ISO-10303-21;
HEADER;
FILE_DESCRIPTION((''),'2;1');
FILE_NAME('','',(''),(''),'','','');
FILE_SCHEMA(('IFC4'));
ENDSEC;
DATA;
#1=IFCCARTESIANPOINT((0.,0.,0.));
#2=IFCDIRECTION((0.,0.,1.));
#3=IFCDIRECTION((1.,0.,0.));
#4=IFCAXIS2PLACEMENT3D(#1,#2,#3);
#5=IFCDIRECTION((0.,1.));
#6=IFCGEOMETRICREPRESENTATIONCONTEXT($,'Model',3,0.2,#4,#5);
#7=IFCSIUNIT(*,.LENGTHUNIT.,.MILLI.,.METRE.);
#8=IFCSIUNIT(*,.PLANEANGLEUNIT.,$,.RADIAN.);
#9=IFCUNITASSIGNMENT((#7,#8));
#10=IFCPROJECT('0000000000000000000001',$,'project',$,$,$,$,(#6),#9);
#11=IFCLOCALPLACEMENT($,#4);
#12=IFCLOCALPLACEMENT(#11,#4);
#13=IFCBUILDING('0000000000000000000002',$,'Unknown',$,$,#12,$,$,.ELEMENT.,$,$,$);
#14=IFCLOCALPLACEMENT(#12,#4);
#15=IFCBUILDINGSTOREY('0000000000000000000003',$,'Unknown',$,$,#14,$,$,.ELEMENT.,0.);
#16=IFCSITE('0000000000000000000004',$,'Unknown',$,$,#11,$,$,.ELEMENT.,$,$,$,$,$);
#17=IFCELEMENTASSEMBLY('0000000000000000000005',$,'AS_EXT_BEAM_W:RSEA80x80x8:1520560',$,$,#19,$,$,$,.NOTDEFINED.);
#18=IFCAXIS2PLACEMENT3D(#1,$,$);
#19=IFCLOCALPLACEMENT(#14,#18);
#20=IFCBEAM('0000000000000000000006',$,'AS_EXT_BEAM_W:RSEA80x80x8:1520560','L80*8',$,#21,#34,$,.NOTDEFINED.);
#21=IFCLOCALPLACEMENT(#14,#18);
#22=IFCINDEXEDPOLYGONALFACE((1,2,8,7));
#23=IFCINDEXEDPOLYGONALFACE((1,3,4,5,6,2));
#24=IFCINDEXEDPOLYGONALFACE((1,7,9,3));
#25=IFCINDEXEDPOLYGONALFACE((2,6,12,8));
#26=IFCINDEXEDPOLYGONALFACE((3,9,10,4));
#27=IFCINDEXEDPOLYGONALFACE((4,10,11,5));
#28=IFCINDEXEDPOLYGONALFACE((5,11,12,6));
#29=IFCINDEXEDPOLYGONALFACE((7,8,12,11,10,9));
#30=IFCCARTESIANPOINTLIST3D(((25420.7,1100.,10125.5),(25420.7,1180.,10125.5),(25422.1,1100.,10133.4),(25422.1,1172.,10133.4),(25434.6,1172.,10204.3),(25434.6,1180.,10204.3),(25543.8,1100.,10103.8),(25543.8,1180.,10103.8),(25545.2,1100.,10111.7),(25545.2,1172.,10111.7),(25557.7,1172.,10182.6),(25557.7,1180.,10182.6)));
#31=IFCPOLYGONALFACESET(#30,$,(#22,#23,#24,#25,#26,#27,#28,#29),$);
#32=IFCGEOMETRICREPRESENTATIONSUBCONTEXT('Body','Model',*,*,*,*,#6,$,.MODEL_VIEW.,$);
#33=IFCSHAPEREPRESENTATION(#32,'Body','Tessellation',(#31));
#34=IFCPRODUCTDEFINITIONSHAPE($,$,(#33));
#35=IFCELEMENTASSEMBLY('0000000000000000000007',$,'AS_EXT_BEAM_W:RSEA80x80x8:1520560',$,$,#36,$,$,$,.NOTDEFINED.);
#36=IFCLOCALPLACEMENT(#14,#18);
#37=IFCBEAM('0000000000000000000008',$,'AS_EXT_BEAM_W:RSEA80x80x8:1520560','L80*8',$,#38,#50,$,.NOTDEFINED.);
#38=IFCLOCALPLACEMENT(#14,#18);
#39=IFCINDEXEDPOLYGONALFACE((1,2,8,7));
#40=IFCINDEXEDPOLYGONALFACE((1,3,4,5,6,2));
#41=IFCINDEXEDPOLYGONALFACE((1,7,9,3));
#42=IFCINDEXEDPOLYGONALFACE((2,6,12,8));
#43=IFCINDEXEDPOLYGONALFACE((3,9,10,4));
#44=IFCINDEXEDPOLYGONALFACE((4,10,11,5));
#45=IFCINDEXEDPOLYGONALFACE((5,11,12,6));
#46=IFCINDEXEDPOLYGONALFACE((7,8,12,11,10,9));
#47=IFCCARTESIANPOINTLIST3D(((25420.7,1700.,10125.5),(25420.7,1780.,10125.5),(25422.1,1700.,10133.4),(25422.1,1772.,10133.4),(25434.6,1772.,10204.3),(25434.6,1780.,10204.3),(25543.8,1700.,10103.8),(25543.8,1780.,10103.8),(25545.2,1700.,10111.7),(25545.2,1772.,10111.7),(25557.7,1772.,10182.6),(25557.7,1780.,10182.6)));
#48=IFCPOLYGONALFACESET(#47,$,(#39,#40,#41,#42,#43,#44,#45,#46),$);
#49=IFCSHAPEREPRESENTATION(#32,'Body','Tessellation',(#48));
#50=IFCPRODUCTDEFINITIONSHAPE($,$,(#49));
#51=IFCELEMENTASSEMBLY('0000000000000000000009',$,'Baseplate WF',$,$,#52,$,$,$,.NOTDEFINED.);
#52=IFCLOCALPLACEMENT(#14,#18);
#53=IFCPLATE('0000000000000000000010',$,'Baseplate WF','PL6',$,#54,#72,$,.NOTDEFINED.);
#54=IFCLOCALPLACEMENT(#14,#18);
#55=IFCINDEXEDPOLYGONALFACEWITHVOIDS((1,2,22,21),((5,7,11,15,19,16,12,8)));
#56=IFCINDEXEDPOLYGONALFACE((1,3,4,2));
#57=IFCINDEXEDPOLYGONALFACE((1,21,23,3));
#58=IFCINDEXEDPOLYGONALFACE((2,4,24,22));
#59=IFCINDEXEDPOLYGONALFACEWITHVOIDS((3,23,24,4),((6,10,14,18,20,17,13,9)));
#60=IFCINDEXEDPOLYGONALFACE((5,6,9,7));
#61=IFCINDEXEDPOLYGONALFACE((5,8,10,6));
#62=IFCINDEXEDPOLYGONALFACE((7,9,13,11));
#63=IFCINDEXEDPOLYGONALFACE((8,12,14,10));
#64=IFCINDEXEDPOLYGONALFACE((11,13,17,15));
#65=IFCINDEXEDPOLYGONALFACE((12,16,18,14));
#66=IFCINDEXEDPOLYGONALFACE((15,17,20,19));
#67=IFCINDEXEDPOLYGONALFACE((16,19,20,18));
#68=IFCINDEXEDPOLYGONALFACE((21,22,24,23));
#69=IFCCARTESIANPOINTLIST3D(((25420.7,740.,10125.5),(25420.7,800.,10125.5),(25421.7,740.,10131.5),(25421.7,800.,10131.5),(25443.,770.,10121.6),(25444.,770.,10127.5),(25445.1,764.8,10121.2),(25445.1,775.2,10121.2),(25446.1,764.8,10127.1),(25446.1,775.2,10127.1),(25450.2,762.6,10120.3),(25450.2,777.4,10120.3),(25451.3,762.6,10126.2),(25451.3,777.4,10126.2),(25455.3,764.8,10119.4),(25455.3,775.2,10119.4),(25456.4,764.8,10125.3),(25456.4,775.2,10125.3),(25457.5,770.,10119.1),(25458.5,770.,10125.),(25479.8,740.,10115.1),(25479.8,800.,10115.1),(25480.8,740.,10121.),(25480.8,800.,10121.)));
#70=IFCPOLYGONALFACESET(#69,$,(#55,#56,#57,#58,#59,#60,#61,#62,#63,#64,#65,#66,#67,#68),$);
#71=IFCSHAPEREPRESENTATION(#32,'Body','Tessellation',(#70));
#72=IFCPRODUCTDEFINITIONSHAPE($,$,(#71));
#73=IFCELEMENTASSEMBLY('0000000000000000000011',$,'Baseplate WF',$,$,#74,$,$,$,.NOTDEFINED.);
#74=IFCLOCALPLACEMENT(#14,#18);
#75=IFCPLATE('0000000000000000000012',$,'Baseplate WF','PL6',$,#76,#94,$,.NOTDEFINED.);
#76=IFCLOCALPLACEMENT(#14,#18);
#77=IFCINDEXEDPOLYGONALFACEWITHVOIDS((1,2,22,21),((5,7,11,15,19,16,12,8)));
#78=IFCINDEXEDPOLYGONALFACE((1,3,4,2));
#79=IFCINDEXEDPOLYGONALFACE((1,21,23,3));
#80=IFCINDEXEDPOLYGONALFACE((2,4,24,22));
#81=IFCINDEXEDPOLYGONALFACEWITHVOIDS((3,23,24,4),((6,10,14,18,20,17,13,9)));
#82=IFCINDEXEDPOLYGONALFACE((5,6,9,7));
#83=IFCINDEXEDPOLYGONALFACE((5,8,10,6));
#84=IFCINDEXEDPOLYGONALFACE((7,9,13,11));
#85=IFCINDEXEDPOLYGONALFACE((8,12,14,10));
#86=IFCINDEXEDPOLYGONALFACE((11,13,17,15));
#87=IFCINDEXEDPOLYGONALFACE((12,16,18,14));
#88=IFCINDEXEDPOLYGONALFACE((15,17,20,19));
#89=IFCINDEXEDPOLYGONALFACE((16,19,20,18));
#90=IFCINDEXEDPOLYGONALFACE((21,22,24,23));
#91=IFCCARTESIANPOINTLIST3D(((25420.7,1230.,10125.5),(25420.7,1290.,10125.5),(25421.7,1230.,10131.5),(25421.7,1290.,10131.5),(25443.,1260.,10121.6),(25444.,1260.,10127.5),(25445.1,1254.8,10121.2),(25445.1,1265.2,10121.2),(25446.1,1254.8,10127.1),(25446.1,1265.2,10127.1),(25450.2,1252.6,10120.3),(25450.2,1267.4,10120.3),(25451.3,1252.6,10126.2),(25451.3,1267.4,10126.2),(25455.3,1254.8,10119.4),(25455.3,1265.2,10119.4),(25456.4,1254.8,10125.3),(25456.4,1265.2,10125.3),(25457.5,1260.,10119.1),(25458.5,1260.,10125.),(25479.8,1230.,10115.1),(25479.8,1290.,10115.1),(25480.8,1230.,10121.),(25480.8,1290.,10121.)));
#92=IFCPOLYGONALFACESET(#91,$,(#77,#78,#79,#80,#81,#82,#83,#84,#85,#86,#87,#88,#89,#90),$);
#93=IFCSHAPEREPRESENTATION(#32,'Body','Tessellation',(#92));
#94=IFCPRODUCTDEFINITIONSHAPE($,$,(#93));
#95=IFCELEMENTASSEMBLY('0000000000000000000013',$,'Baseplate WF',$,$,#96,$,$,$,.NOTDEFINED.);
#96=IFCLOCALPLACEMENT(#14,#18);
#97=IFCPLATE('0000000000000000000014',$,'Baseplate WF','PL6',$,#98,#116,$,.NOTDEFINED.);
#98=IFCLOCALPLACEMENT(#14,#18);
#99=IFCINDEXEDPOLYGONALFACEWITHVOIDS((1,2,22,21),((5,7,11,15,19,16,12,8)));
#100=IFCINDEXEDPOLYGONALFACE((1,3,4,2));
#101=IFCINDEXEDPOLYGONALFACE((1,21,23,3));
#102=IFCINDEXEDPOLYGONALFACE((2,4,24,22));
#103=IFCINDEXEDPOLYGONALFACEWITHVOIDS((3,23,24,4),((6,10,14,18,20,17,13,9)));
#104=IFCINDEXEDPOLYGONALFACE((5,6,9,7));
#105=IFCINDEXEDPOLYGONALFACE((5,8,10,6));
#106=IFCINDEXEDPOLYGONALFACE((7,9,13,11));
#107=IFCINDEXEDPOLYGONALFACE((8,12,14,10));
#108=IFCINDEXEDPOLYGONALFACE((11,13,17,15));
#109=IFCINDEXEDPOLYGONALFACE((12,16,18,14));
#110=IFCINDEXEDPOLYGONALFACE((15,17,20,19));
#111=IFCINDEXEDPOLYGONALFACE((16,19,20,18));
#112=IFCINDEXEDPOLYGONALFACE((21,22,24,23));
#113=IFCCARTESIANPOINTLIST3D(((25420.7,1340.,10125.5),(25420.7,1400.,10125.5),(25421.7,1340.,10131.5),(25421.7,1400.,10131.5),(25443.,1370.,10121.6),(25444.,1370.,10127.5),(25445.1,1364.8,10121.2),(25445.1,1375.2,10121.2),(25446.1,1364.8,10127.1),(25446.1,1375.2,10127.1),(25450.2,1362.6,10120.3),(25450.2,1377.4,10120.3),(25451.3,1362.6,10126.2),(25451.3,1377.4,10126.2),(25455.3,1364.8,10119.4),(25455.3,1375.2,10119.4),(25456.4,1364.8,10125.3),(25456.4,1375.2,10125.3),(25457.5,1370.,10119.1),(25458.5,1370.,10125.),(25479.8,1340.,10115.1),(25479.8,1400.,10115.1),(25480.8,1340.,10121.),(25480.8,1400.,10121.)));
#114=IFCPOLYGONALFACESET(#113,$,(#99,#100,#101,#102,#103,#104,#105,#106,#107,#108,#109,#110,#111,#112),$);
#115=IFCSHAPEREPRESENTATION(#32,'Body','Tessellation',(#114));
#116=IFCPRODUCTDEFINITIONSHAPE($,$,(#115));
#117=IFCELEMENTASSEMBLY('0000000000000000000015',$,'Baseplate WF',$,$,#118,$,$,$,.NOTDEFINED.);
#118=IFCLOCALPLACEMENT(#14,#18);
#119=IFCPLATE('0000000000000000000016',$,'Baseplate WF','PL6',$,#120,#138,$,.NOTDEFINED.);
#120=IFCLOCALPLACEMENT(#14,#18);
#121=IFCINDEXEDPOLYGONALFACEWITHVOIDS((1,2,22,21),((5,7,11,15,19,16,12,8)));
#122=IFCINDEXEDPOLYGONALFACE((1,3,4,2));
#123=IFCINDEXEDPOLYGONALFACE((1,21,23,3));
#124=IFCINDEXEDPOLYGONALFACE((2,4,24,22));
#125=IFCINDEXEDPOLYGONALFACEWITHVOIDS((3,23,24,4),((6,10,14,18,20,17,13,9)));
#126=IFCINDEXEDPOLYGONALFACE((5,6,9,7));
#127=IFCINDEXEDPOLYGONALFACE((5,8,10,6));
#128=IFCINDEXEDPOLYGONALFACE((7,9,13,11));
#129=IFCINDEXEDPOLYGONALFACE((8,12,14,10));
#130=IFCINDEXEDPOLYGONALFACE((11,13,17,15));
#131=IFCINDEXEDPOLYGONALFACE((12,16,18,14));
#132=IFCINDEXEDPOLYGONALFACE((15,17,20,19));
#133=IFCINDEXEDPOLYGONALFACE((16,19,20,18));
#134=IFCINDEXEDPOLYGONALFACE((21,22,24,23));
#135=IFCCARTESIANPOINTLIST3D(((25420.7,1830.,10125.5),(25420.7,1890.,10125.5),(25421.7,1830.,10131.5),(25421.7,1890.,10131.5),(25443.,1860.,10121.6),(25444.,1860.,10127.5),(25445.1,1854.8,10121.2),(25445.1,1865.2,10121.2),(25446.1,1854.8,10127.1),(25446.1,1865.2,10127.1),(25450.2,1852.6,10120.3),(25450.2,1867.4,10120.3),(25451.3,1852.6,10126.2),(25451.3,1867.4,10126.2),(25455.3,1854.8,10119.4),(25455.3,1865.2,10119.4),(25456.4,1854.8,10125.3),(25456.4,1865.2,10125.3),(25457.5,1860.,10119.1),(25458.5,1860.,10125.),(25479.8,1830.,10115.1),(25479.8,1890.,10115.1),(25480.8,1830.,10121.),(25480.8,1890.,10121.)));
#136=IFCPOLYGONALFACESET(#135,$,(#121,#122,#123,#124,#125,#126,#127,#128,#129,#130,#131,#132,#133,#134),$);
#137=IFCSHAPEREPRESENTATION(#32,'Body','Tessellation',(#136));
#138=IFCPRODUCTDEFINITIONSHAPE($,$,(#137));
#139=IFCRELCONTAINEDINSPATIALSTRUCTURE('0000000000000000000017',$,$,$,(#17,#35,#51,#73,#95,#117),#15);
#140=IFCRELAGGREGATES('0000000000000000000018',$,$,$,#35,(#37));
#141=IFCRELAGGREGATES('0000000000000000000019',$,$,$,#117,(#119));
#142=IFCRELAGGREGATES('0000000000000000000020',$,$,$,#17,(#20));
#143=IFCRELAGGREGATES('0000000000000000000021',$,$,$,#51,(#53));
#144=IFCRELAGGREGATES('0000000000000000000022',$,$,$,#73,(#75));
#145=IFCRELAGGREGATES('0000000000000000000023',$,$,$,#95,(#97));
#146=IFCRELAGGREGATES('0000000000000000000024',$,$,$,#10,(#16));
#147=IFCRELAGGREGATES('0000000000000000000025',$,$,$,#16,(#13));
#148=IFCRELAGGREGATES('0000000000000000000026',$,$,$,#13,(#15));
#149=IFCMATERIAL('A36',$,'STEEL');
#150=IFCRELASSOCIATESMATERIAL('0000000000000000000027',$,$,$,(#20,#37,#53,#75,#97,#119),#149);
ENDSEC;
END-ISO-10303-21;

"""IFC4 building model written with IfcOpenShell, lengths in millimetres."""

from ifc_helpers import new_model, si_unit, direction, frame, origin_with_axes, place, context, subcontext, project, spatial, line, indexed_curve, outline, extrude, material, element, aggregate, save


model = new_model("IFC4")

# Units and contexts
model_context = context("Model", 3, precision=0.2, world=origin_with_axes(), true_north=direction((0.0, 1.0)))
body_context = subcontext(model_context, "Body", "Model", "MODEL_VIEW")
ifc_project = project(units=[si_unit("LENGTHUNIT", "METRE", prefix="MILLI"), si_unit("PLANEANGLEUNIT", "RADIAN")], contexts=[model_context])

# Site, building, storey
site_placement = place(None, origin_with_axes())
site = spatial("IfcSite", under=ifc_project, at=site_placement, Name="Unknown", CompositionType="ELEMENT")
building_placement = place(site_placement, origin_with_axes())
building = spatial("IfcBuilding", under=site, at=building_placement, Name="Unknown", CompositionType="ELEMENT")
storey_placement = place(building_placement, origin_with_axes())
storey = spatial("IfcBuildingStorey", under=building, at=storey_placement, Name="Unknown", CompositionType="ELEMENT", Elevation=0.0)

# Element assemblies, beams
assembly_1_placement = place(storey_placement, frame((25427.6, 1140.0, 10164.9), z_axis=(0.0, -1.0, 0.0), x_axis=(0.984808, 0.0, -0.173648)))
assembly_1 = element("IfcElementAssembly", 1, at=assembly_1_placement, inside=storey, Name="AS_EXT_BEAM_W:RSEA80x80x8:1520560", PredefinedType="NOTDEFINED")
ifc_material_1 = material(Name="A36", Category="STEEL")
beam_1_placement = place(assembly_1_placement, origin_with_axes())
beam_1 = element("IfcBeam", 2, at=beam_1_placement, material=ifc_material_1, Name="AS_EXT_BEAM_W:RSEA80x80x8:1520560", Description="L80*8", PredefinedType="NOTDEFINED", context=body_context, shape_type="SolidModel", body=[
    extrude(outline(indexed_curve([(-40.0, -40.0), (40.0, -40.0), (40.0, -32.0), (-32.0, -32.0), (-32.0, 40.0), (-40.0, 40.0)], segments=[line(1, 2, 3, 4, 5, 6, 1)])), frame((0.0, 0.0, 0.0), z_axis=(-1.0, 0.0, 0.0), x_axis=(0.0, 0.0, 1.0)), (0.0, 0.0, -1.0), 125.0),
])
assembly_2_placement = place(storey_placement, frame((25427.6, 1740.0, 10164.9), z_axis=(0.0, -1.0, 0.0), x_axis=(0.984808, 0.0, -0.173648)))
assembly_2 = element("IfcElementAssembly", 3, at=assembly_2_placement, inside=storey, Name="AS_EXT_BEAM_W:RSEA80x80x8:1520560", PredefinedType="NOTDEFINED")
beam_2_placement = place(assembly_2_placement, origin_with_axes())
beam_2 = element("IfcBeam", 4, at=beam_2_placement, material=ifc_material_1, Name="AS_EXT_BEAM_W:RSEA80x80x8:1520560", Description="L80*8", PredefinedType="NOTDEFINED", context=body_context, shape_type="SolidModel", body=[
    extrude(outline(indexed_curve([(-40.0, -40.0), (40.0, -40.0), (40.0, -32.0), (-32.0, -32.0), (-32.0, 40.0), (-40.0, 40.0)], segments=[line(1, 2, 3, 4, 5, 6, 1)])), frame((0.0, 0.0, 0.0), z_axis=(-1.0, 0.0, 0.0), x_axis=(0.0, 0.0, 1.0)), (0.0, 0.0, -1.0), 125.0),
])
aggregate(assembly_2, [beam_2])

# Element assemblies, plates, voiding features
assembly_3_placement = place(storey_placement, frame((25480.3, 800.0, 10118.1), z_axis=(-0.173648, 0.0, -0.984808), x_axis=(0.0, -1.0, 0.0)))
assembly_3 = element("IfcElementAssembly", 5, at=assembly_3_placement, inside=storey, Name="Baseplate WF", PredefinedType="NOTDEFINED")
plate_1_placement = place(assembly_3_placement, origin_with_axes())
plate_1 = element("IfcPlate", 6, at=plate_1_placement, material=ifc_material_1, Name="Baseplate WF", Description="PL6", PredefinedType="NOTDEFINED", context=body_context, shape_type="SolidModel", body=[
    extrude(outline(indexed_curve([(0.0, 0.0), (60.0, 0.0), (60.0, 60.0), (0.0, 60.0)], segments=[line(1, 2, 3, 4, 1)])), frame((0.0, 0.0, 3.0), z_axis=(0.0, 0.0, 1.0), x_axis=(1.0, 0.0, 0.0)), (0.0, 0.0, -1.0), 6.0),
])
voiding_feature_1_placement = place(plate_1_placement, frame((140.0, 30.0, -3.5), z_axis=(-1.0, 0.0, 0.0), x_axis=(0.0, 0.0, 1.0)))
element("IfcVoidingFeature", 7, at=voiding_feature_1_placement, cuts=plate_1, Name="BEAM", PredefinedType="HOLE", context=body_context, shape_type="SolidModel", body=[
    extrude(outline(indexed_curve([(7.4, 0.0), (5.2, 5.2), (0.0, 7.4), (-5.2, 5.2), (-7.4, 0.0), (-5.2, -5.2), (0.0, -7.4), (5.2, -5.2)], segments=[line(1, 2, 3, 4, 5, 6, 7, 8, 1)])), frame((0.0, 0.0, 0.0), z_axis=(-1.0, 0.0, 0.0), x_axis=(0.0, 0.0, 1.0)), (0.0, 0.0, -1.0), 7.0),
])
voiding_feature_2_placement = place(plate_1_placement, frame((30.0, 30.0, -3.5), z_axis=(-1.0, 0.0, 0.0), x_axis=(0.0, 0.0, 1.0)))
element("IfcVoidingFeature", 8, at=voiding_feature_2_placement, cuts=plate_1, Name="BEAM", PredefinedType="HOLE", context=body_context, shape_type="SolidModel", body=[
    extrude(outline(indexed_curve([(7.4, 0.0), (5.2, 5.2), (0.0, 7.4), (-5.2, 5.2), (-7.4, 0.0), (-5.2, -5.2), (0.0, -7.4), (5.2, -5.2)], segments=[line(1, 2, 3, 4, 5, 6, 7, 8, 1)])), frame((0.0, 0.0, 0.0), z_axis=(-1.0, 0.0, 0.0), x_axis=(0.0, 0.0, 1.0)), (0.0, 0.0, -1.0), 7.0),
])
assembly_4_placement = place(storey_placement, frame((25480.3, 1290.0, 10118.1), z_axis=(-0.173648, 0.0, -0.984808), x_axis=(0.0, -1.0, 0.0)))
assembly_4 = element("IfcElementAssembly", 9, at=assembly_4_placement, inside=storey, Name="Baseplate WF", PredefinedType="NOTDEFINED")
plate_2_placement = place(assembly_4_placement, origin_with_axes())
plate_2 = element("IfcPlate", 10, at=plate_2_placement, material=ifc_material_1, Name="Baseplate WF", Description="PL6", PredefinedType="NOTDEFINED", context=body_context, shape_type="SolidModel", body=[
    extrude(outline(indexed_curve([(0.0, 0.0), (60.0, 0.0), (60.0, 60.0), (0.0, 60.0)], segments=[line(1, 2, 3, 4, 1)])), frame((0.0, 0.0, 3.0), z_axis=(0.0, 0.0, 1.0), x_axis=(1.0, 0.0, 0.0)), (0.0, 0.0, -1.0), 6.0),
])
voiding_feature_3_placement = place(plate_2_placement, frame((30.0, 30.0, -3.5), z_axis=(-1.0, 0.0, 0.0), x_axis=(0.0, 0.0, 1.0)))
element("IfcVoidingFeature", 11, at=voiding_feature_3_placement, cuts=plate_2, Name="BEAM", PredefinedType="HOLE", context=body_context, shape_type="SolidModel", body=[
    extrude(outline(indexed_curve([(7.4, 0.0), (5.2, 5.2), (0.0, 7.4), (-5.2, 5.2), (-7.4, 0.0), (-5.2, -5.2), (0.0, -7.4), (5.2, -5.2)], segments=[line(1, 2, 3, 4, 5, 6, 7, 8, 1)])), frame((0.0, 0.0, 0.0), z_axis=(-1.0, 0.0, 0.0), x_axis=(0.0, 0.0, 1.0)), (0.0, 0.0, -1.0), 7.0),
])
voiding_feature_4_placement = place(plate_2_placement, frame((-80.0, 30.0, -3.5), z_axis=(-1.0, 0.0, 0.0), x_axis=(0.0, 0.0, 1.0)))
element("IfcVoidingFeature", 12, at=voiding_feature_4_placement, cuts=plate_2, Name="BEAM", PredefinedType="HOLE", context=body_context, shape_type="SolidModel", body=[
    extrude(outline(indexed_curve([(7.4, 0.0), (5.2, 5.2), (0.0, 7.4), (-5.2, 5.2), (-7.4, 0.0), (-5.2, -5.2), (0.0, -7.4), (5.2, -5.2)], segments=[line(1, 2, 3, 4, 5, 6, 7, 8, 1)])), frame((0.0, 0.0, 0.0), z_axis=(-1.0, 0.0, 0.0), x_axis=(0.0, 0.0, 1.0)), (0.0, 0.0, -1.0), 7.0),
])
assembly_5_placement = place(storey_placement, frame((25480.3, 1400.0, 10118.1), z_axis=(-0.173648, 0.0, -0.984808), x_axis=(0.0, -1.0, 0.0)))
assembly_5 = element("IfcElementAssembly", 13, at=assembly_5_placement, inside=storey, Name="Baseplate WF", PredefinedType="NOTDEFINED")
plate_3_placement = place(assembly_5_placement, origin_with_axes())
plate_3 = element("IfcPlate", 14, at=plate_3_placement, material=ifc_material_1, Name="Baseplate WF", Description="PL6", PredefinedType="NOTDEFINED", context=body_context, shape_type="SolidModel", body=[
    extrude(outline(indexed_curve([(0.0, 0.0), (60.0, 0.0), (60.0, 60.0), (0.0, 60.0)], segments=[line(1, 2, 3, 4, 1)])), frame((0.0, 0.0, 3.0), z_axis=(0.0, 0.0, 1.0), x_axis=(1.0, 0.0, 0.0)), (0.0, 0.0, -1.0), 6.0),
])
voiding_feature_5_placement = place(plate_3_placement, frame((140.0, 30.0, -3.5), z_axis=(-1.0, 0.0, 0.0), x_axis=(0.0, 0.0, 1.0)))
element("IfcVoidingFeature", 15, at=voiding_feature_5_placement, cuts=plate_3, Name="BEAM", PredefinedType="HOLE", context=body_context, shape_type="SolidModel", body=[
    extrude(outline(indexed_curve([(7.4, 0.0), (5.2, 5.2), (0.0, 7.4), (-5.2, 5.2), (-7.4, 0.0), (-5.2, -5.2), (0.0, -7.4), (5.2, -5.2)], segments=[line(1, 2, 3, 4, 5, 6, 7, 8, 1)])), frame((0.0, 0.0, 0.0), z_axis=(-1.0, 0.0, 0.0), x_axis=(0.0, 0.0, 1.0)), (0.0, 0.0, -1.0), 7.0),
])
voiding_feature_6_placement = place(plate_3_placement, frame((30.0, 30.0, -3.5), z_axis=(-1.0, 0.0, 0.0), x_axis=(0.0, 0.0, 1.0)))
element("IfcVoidingFeature", 16, at=voiding_feature_6_placement, cuts=plate_3, Name="BEAM", PredefinedType="HOLE", context=body_context, shape_type="SolidModel", body=[
    extrude(outline(indexed_curve([(7.4, 0.0), (5.2, 5.2), (0.0, 7.4), (-5.2, 5.2), (-7.4, 0.0), (-5.2, -5.2), (0.0, -7.4), (5.2, -5.2)], segments=[line(1, 2, 3, 4, 5, 6, 7, 8, 1)])), frame((0.0, 0.0, 0.0), z_axis=(-1.0, 0.0, 0.0), x_axis=(0.0, 0.0, 1.0)), (0.0, 0.0, -1.0), 7.0),
])
assembly_6_placement = place(storey_placement, frame((25480.3, 1890.0, 10118.1), z_axis=(-0.173648, 0.0, -0.984808), x_axis=(0.0, -1.0, 0.0)))
assembly_6 = element("IfcElementAssembly", 17, at=assembly_6_placement, inside=storey, Name="Baseplate WF", PredefinedType="NOTDEFINED")
plate_4_placement = place(assembly_6_placement, origin_with_axes())
plate_4 = element("IfcPlate", 18, at=plate_4_placement, material=ifc_material_1, Name="Baseplate WF", Description="PL6", PredefinedType="NOTDEFINED", context=body_context, shape_type="SolidModel", body=[
    extrude(outline(indexed_curve([(0.0, 0.0), (60.0, 0.0), (60.0, 60.0), (0.0, 60.0)], segments=[line(1, 2, 3, 4, 1)])), frame((0.0, 0.0, 3.0), z_axis=(0.0, 0.0, 1.0), x_axis=(1.0, 0.0, 0.0)), (0.0, 0.0, -1.0), 6.0),
])
voiding_feature_7_placement = place(plate_4_placement, frame((30.0, 30.0, -3.5), z_axis=(-1.0, 0.0, 0.0), x_axis=(0.0, 0.0, 1.0)))
element("IfcVoidingFeature", 19, at=voiding_feature_7_placement, cuts=plate_4, Name="BEAM", PredefinedType="HOLE", context=body_context, shape_type="SolidModel", body=[
    extrude(outline(indexed_curve([(7.4, 0.0), (5.2, 5.2), (0.0, 7.4), (-5.2, 5.2), (-7.4, 0.0), (-5.2, -5.2), (0.0, -7.4), (5.2, -5.2)], segments=[line(1, 2, 3, 4, 5, 6, 7, 8, 1)])), frame((0.0, 0.0, 0.0), z_axis=(-1.0, 0.0, 0.0), x_axis=(0.0, 0.0, 1.0)), (0.0, 0.0, -1.0), 7.0),
])
voiding_feature_8_placement = place(plate_4_placement, frame((-80.0, 30.0, -3.5), z_axis=(-1.0, 0.0, 0.0), x_axis=(0.0, 0.0, 1.0)))
element("IfcVoidingFeature", 20, at=voiding_feature_8_placement, cuts=plate_4, Name="BEAM", PredefinedType="HOLE", context=body_context, shape_type="SolidModel", body=[
    extrude(outline(indexed_curve([(7.4, 0.0), (5.2, 5.2), (0.0, 7.4), (-5.2, 5.2), (-7.4, 0.0), (-5.2, -5.2), (0.0, -7.4), (5.2, -5.2)], segments=[line(1, 2, 3, 4, 5, 6, 7, 8, 1)])), frame((0.0, 0.0, 0.0), z_axis=(-1.0, 0.0, 0.0), x_axis=(0.0, 0.0, 1.0)), (0.0, 0.0, -1.0), 7.0),
])
aggregate(assembly_6, [plate_4])

aggregate(assembly_1, [beam_1])

aggregate(assembly_3, [plate_1])
aggregate(assembly_4, [plate_2])
aggregate(assembly_5, [plate_3])

save(model, "model.ifc")
